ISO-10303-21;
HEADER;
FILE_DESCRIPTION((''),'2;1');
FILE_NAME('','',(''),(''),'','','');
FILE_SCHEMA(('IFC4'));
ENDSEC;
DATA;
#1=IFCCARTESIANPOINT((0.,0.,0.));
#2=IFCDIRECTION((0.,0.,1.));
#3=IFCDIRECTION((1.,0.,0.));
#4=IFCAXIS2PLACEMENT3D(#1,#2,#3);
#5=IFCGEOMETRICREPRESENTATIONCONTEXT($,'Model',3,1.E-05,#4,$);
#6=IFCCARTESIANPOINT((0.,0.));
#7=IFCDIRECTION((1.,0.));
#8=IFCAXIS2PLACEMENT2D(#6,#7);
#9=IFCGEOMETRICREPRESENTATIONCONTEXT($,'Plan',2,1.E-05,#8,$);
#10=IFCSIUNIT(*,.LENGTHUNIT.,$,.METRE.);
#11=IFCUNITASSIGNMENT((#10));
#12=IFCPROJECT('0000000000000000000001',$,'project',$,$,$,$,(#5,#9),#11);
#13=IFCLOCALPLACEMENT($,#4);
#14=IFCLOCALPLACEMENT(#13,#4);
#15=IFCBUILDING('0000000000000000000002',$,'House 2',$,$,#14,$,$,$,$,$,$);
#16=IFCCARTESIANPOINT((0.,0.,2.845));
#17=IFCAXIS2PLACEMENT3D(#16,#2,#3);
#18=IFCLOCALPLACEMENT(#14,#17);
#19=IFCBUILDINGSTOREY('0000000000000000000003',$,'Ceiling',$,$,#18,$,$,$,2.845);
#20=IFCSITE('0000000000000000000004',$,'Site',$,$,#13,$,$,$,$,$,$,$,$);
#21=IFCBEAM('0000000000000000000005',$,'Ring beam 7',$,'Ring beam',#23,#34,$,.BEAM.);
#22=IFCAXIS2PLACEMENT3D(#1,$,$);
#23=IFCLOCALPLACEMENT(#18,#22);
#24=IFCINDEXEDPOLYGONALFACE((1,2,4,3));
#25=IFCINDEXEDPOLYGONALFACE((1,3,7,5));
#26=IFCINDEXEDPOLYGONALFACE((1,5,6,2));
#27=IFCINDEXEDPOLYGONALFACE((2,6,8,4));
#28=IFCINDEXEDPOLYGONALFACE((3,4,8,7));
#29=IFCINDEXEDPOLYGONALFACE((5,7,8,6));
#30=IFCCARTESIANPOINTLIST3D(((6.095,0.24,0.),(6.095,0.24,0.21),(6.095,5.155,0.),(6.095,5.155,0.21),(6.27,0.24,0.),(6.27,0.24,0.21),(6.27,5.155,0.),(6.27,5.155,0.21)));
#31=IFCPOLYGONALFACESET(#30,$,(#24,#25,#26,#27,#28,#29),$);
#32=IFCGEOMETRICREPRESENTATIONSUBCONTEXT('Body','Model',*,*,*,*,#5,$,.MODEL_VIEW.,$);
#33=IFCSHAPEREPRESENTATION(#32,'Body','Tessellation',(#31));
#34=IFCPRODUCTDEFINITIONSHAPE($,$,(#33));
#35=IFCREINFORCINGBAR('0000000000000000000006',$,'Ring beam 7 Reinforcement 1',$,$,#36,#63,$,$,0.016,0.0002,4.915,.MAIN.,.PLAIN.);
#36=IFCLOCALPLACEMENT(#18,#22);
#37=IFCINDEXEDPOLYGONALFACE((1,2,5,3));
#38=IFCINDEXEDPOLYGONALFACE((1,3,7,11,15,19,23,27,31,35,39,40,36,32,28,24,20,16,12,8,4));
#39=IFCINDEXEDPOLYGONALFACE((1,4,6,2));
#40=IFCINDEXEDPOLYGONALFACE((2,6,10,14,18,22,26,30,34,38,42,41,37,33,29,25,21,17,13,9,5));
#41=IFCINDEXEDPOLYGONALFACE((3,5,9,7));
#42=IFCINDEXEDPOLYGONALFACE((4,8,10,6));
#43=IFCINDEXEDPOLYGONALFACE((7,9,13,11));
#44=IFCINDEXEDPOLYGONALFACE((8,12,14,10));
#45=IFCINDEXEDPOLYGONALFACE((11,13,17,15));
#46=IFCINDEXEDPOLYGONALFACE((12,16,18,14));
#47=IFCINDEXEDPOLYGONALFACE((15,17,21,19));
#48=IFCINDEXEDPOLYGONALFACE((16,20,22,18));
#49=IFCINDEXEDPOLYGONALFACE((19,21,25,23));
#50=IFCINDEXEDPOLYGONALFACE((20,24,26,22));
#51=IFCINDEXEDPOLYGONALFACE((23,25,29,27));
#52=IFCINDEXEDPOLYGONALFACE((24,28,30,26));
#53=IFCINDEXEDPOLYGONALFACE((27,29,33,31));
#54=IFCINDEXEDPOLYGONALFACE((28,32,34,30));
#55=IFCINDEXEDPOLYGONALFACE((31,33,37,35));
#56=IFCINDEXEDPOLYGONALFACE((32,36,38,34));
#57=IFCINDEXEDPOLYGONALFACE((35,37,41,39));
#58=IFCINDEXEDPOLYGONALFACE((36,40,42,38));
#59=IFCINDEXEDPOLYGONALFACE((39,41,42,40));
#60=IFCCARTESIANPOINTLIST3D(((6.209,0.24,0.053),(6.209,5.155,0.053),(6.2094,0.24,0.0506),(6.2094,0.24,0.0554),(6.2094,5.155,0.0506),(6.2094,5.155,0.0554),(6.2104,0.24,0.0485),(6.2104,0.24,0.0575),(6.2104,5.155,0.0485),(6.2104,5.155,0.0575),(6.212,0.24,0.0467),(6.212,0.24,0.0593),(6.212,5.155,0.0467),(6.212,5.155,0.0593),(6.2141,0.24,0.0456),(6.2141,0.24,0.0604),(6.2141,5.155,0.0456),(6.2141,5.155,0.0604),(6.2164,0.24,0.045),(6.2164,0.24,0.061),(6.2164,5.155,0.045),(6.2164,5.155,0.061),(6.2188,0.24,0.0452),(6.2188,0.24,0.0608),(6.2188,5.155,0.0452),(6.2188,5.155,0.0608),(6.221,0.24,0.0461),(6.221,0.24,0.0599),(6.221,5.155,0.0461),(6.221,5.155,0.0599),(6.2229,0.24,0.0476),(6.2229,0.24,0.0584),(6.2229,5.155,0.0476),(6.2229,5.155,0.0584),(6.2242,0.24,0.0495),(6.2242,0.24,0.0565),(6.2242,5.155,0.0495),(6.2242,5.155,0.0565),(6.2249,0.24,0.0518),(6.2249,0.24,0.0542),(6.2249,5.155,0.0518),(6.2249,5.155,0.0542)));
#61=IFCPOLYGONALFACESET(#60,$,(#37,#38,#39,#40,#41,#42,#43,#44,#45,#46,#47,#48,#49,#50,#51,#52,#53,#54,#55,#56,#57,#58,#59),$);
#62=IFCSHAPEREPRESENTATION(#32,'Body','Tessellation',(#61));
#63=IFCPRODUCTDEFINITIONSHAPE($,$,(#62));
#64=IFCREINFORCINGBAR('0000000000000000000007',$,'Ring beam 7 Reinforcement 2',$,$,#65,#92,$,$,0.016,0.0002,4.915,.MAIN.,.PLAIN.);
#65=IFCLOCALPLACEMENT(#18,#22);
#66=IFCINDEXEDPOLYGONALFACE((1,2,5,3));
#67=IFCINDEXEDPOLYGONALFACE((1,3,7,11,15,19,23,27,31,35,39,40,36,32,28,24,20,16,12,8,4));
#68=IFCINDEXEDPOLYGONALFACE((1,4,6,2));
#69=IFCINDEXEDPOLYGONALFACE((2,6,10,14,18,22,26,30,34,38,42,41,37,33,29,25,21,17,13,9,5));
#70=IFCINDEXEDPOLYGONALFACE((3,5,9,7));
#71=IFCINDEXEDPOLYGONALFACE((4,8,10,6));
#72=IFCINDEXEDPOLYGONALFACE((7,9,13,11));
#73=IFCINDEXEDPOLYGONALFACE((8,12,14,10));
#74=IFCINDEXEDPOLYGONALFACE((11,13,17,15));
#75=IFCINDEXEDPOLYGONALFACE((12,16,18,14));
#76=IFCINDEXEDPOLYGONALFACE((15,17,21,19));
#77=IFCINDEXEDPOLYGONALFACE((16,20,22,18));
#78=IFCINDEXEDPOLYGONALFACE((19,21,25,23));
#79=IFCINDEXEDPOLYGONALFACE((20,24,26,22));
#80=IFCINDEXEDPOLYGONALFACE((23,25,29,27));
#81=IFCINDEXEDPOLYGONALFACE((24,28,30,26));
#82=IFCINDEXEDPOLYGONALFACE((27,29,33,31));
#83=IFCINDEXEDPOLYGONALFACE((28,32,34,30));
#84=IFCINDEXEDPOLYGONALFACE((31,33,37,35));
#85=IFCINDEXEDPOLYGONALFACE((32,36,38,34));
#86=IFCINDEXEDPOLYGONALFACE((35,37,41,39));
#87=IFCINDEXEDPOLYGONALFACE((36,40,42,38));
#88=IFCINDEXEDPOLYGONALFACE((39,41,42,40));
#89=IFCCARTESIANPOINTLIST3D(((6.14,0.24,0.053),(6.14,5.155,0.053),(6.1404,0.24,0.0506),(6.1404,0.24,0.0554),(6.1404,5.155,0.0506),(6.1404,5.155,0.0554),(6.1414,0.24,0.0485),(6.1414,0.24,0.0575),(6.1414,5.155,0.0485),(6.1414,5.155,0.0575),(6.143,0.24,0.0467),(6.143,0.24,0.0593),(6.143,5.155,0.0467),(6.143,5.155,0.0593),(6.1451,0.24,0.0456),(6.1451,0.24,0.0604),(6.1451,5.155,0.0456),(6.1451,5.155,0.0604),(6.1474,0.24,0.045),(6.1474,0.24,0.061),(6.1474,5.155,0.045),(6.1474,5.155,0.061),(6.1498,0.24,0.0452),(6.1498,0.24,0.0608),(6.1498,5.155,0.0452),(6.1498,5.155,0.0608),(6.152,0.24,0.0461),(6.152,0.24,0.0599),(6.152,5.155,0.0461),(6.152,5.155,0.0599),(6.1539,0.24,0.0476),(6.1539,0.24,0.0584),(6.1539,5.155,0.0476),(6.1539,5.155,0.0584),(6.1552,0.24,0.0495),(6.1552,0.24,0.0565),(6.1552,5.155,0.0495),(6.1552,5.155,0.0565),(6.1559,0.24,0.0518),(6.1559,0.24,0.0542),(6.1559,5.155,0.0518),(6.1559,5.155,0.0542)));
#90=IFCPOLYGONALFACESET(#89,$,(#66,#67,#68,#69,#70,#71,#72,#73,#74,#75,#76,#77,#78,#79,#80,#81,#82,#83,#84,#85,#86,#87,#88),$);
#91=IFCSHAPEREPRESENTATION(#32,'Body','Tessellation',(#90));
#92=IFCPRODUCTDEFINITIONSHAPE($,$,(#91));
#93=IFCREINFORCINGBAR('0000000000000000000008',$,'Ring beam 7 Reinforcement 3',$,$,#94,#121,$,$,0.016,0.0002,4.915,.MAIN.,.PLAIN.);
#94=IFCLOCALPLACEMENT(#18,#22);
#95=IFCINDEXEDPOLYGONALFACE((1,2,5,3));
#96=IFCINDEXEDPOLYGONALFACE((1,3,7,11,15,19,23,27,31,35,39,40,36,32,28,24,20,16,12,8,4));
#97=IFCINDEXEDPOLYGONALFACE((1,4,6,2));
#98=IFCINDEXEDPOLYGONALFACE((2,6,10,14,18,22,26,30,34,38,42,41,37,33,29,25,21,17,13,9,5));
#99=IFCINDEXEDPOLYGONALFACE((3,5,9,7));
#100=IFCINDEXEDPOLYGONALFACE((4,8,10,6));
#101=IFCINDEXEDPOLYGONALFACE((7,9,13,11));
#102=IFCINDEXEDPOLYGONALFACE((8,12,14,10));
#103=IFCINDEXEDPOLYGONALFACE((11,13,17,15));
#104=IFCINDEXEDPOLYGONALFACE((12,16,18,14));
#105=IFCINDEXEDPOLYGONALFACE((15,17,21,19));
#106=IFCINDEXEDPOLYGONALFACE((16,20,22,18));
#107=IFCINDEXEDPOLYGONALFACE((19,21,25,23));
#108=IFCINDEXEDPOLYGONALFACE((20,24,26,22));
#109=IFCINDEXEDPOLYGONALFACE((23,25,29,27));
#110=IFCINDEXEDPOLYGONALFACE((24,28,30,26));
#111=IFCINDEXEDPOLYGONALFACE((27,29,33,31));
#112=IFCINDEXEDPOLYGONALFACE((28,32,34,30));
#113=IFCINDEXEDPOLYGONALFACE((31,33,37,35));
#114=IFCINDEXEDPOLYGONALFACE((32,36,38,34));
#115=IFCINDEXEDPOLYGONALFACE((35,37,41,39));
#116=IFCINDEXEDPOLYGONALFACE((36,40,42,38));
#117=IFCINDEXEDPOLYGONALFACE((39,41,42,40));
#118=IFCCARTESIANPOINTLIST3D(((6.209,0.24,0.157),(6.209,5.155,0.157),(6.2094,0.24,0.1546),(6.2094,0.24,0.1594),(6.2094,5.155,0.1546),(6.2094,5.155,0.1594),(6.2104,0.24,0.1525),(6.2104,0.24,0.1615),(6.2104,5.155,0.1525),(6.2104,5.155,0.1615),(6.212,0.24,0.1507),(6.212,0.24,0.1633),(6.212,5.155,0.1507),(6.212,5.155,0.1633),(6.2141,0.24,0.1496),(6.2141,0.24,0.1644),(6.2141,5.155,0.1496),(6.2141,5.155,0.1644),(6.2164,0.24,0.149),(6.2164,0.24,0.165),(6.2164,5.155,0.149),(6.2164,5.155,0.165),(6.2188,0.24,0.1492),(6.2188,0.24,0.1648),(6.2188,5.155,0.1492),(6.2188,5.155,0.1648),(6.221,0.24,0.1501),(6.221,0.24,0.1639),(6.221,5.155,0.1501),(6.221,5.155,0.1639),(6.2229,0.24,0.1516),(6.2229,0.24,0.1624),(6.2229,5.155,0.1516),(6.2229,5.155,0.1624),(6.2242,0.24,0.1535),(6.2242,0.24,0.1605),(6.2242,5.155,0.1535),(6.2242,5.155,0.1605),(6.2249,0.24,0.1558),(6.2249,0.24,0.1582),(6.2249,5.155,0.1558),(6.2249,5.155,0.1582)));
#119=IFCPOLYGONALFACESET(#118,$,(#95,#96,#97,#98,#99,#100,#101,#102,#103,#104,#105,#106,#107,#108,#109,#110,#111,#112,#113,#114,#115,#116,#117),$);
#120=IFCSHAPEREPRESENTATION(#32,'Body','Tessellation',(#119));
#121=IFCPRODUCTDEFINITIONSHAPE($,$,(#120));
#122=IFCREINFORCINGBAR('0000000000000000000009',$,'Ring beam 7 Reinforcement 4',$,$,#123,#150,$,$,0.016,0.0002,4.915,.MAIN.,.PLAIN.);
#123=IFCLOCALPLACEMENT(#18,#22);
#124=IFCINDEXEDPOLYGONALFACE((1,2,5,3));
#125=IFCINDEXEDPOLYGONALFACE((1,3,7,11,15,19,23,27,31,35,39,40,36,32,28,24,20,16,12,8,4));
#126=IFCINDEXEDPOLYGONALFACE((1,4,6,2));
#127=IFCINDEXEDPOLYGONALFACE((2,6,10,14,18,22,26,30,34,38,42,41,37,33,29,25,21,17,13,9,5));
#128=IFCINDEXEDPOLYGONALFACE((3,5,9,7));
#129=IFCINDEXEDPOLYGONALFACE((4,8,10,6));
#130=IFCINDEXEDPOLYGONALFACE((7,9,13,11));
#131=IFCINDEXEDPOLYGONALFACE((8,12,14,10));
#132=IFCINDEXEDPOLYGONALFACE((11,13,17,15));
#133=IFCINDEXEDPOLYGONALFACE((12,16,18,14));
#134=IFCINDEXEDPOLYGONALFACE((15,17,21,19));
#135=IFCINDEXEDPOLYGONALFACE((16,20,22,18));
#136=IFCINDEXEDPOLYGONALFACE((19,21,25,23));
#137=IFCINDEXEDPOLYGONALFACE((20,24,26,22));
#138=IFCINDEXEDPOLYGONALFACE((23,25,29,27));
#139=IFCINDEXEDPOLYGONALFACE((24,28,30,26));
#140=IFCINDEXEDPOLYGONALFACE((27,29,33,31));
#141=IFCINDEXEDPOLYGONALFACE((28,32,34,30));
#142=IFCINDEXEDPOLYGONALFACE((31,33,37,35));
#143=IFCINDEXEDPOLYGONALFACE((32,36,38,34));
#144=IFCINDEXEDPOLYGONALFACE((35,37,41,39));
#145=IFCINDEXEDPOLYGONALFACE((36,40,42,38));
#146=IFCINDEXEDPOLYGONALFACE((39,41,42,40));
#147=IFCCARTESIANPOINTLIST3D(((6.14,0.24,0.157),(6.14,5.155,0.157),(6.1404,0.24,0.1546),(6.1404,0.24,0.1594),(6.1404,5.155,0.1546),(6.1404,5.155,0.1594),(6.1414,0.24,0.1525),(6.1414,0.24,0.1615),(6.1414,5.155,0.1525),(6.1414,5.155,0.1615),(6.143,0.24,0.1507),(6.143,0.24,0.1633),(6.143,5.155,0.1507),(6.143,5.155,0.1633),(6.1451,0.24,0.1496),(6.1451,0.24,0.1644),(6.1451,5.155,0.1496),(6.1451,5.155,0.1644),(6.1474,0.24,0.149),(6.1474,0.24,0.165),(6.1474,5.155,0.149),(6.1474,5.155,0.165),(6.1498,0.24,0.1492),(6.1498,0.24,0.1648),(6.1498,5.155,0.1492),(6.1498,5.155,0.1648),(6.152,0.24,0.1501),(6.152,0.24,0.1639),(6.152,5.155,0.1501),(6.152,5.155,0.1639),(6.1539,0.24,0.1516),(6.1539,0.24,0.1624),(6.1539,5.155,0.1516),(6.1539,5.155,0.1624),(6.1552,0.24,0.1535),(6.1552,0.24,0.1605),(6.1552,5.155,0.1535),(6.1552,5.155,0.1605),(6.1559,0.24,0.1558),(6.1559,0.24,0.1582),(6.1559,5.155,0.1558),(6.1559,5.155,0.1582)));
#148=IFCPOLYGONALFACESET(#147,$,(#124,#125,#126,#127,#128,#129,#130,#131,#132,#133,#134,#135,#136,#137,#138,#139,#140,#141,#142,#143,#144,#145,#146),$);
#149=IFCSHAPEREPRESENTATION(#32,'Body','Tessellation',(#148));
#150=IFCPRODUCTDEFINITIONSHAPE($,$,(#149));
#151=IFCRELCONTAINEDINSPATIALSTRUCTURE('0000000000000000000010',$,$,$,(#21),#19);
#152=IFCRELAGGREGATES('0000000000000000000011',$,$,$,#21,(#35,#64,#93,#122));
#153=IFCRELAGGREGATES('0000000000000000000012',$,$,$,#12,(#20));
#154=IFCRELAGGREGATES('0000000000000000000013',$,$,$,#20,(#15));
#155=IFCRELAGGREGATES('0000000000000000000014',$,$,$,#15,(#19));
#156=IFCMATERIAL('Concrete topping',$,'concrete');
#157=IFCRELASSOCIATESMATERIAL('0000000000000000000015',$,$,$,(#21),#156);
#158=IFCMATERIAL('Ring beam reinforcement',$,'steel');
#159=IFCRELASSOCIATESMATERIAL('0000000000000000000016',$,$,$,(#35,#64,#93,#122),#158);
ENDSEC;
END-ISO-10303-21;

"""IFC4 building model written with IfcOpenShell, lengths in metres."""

from ifc_helpers import new_model, si_unit, frame, origin_with_axes, origin_2d, origin_2d_with_axis, place, context, subcontext, project, spatial, circle_curve, rectangle, outline, extrude, material, element, aggregate, save


model = new_model("IFC4")

# Units and contexts
model_context = context("Model", 3, precision=1e-05, world=origin_with_axes())
plan_context = context("Plan", 2, precision=1e-05, world=origin_2d_with_axis())
body_context = subcontext(model_context, "Body", "Model", "MODEL_VIEW")
ifc_project = project(units=[si_unit("LENGTHUNIT", "METRE")], contexts=[model_context, plan_context])

# Site, building, storey
site_placement = place(None, origin_with_axes())
site = spatial("IfcSite", under=ifc_project, at=site_placement, Name="Site")
building_placement = place(site_placement, origin_with_axes())
building = spatial("IfcBuilding", under=site, at=building_placement, Name="House 2")
storey_placement = place(building_placement, frame((0.0, 0.0, 2.845), z_axis=(0.0, 0.0, 1.0), x_axis=(1.0, 0.0, 0.0)))
storey = spatial("IfcBuildingStorey", under=building, at=storey_placement, Name="Ceiling", Elevation=2.845)

# Beam, reinforcing bars
ifc_material_1 = material(Name="Concrete topping", Category="concrete")
beam_placement = place(storey_placement, frame((6.1825, 0.24, 0.105), z_axis=(0.0, 0.0, 1.0), x_axis=(0.0, 1.0, 0.0)))
beam = element("IfcBeam", 1, at=beam_placement, inside=storey, material=ifc_material_1, Name="Ring beam 7", ObjectType="Ring beam", PredefinedType="BEAM", context=body_context, shape_type="SweptSolid", body=[
    extrude(rectangle(XDim=0.175, YDim=0.21), frame((0.0, 0.0, 0.0), z_axis=(1.0, 0.0, 0.0), x_axis=(0.0, 1.0, 0.0)), (0.0, 0.0, 1.0), 4.915),
])
ifc_material_2 = material(Name="Ring beam reinforcement", Category="steel")
reinforcing_bar_1_placement = place(beam_placement, frame((0.0, -0.0345, -0.052), z_axis=(0.0, 0.0, 1.0), x_axis=(1.0, 0.0, 0.0)))
reinforcing_bar_1 = element("IfcReinforcingBar", 2, at=reinforcing_bar_1_placement, material=ifc_material_2, Name="Ring beam 7 Reinforcement 1", BarLength=4.915, BarSurface="PLAIN", CrossSectionArea=0.0002, NominalDiameter=0.016, PredefinedType="MAIN", context=body_context, shape_type="SweptSolid", body=[
    extrude(outline(circle_curve(origin_2d(), 0.008)), frame((0.0, 0.0, 0.0), z_axis=(1.0, 0.0, 0.0), x_axis=(0.0, 1.0, 0.0)), (0.0, 0.0, 1.0), 4.915),
])
reinforcing_bar_2_placement = place(beam_placement, frame((0.0, 0.0345, -0.052), z_axis=(0.0, 0.0, 1.0), x_axis=(1.0, 0.0, 0.0)))
reinforcing_bar_2 = element("IfcReinforcingBar", 3, at=reinforcing_bar_2_placement, material=ifc_material_2, Name="Ring beam 7 Reinforcement 2", BarLength=4.915, BarSurface="PLAIN", CrossSectionArea=0.0002, NominalDiameter=0.016, PredefinedType="MAIN", context=body_context, shape_type="SweptSolid", body=[
    extrude(outline(circle_curve(origin_2d(), 0.008)), frame((0.0, 0.0, 0.0), z_axis=(1.0, 0.0, 0.0), x_axis=(0.0, 1.0, 0.0)), (0.0, 0.0, 1.0), 4.915),
])
reinforcing_bar_3_placement = place(beam_placement, frame((0.0, -0.0345, 0.052), z_axis=(0.0, 0.0, 1.0), x_axis=(1.0, 0.0, 0.0)))
reinforcing_bar_3 = element("IfcReinforcingBar", 4, at=reinforcing_bar_3_placement, material=ifc_material_2, Name="Ring beam 7 Reinforcement 3", BarLength=4.915, BarSurface="PLAIN", CrossSectionArea=0.0002, NominalDiameter=0.016, PredefinedType="MAIN", context=body_context, shape_type="SweptSolid", body=[
    extrude(outline(circle_curve(origin_2d(), 0.008)), frame((0.0, 0.0, 0.0), z_axis=(1.0, 0.0, 0.0), x_axis=(0.0, 1.0, 0.0)), (0.0, 0.0, 1.0), 4.915),
])
reinforcing_bar_4_placement = place(beam_placement, frame((0.0, 0.0345, 0.052), z_axis=(0.0, 0.0, 1.0), x_axis=(1.0, 0.0, 0.0)))
reinforcing_bar_4 = element("IfcReinforcingBar", 5, at=reinforcing_bar_4_placement, material=ifc_material_2, Name="Ring beam 7 Reinforcement 4", BarLength=4.915, BarSurface="PLAIN", CrossSectionArea=0.0002, NominalDiameter=0.016, PredefinedType="MAIN", context=body_context, shape_type="SweptSolid", body=[
    extrude(outline(circle_curve(origin_2d(), 0.008)), frame((0.0, 0.0, 0.0), z_axis=(1.0, 0.0, 0.0), x_axis=(0.0, 1.0, 0.0)), (0.0, 0.0, 1.0), 4.915),
])
aggregate(beam, [reinforcing_bar_1, reinforcing_bar_2, reinforcing_bar_3, reinforcing_bar_4])

save(model, "model.ifc")
